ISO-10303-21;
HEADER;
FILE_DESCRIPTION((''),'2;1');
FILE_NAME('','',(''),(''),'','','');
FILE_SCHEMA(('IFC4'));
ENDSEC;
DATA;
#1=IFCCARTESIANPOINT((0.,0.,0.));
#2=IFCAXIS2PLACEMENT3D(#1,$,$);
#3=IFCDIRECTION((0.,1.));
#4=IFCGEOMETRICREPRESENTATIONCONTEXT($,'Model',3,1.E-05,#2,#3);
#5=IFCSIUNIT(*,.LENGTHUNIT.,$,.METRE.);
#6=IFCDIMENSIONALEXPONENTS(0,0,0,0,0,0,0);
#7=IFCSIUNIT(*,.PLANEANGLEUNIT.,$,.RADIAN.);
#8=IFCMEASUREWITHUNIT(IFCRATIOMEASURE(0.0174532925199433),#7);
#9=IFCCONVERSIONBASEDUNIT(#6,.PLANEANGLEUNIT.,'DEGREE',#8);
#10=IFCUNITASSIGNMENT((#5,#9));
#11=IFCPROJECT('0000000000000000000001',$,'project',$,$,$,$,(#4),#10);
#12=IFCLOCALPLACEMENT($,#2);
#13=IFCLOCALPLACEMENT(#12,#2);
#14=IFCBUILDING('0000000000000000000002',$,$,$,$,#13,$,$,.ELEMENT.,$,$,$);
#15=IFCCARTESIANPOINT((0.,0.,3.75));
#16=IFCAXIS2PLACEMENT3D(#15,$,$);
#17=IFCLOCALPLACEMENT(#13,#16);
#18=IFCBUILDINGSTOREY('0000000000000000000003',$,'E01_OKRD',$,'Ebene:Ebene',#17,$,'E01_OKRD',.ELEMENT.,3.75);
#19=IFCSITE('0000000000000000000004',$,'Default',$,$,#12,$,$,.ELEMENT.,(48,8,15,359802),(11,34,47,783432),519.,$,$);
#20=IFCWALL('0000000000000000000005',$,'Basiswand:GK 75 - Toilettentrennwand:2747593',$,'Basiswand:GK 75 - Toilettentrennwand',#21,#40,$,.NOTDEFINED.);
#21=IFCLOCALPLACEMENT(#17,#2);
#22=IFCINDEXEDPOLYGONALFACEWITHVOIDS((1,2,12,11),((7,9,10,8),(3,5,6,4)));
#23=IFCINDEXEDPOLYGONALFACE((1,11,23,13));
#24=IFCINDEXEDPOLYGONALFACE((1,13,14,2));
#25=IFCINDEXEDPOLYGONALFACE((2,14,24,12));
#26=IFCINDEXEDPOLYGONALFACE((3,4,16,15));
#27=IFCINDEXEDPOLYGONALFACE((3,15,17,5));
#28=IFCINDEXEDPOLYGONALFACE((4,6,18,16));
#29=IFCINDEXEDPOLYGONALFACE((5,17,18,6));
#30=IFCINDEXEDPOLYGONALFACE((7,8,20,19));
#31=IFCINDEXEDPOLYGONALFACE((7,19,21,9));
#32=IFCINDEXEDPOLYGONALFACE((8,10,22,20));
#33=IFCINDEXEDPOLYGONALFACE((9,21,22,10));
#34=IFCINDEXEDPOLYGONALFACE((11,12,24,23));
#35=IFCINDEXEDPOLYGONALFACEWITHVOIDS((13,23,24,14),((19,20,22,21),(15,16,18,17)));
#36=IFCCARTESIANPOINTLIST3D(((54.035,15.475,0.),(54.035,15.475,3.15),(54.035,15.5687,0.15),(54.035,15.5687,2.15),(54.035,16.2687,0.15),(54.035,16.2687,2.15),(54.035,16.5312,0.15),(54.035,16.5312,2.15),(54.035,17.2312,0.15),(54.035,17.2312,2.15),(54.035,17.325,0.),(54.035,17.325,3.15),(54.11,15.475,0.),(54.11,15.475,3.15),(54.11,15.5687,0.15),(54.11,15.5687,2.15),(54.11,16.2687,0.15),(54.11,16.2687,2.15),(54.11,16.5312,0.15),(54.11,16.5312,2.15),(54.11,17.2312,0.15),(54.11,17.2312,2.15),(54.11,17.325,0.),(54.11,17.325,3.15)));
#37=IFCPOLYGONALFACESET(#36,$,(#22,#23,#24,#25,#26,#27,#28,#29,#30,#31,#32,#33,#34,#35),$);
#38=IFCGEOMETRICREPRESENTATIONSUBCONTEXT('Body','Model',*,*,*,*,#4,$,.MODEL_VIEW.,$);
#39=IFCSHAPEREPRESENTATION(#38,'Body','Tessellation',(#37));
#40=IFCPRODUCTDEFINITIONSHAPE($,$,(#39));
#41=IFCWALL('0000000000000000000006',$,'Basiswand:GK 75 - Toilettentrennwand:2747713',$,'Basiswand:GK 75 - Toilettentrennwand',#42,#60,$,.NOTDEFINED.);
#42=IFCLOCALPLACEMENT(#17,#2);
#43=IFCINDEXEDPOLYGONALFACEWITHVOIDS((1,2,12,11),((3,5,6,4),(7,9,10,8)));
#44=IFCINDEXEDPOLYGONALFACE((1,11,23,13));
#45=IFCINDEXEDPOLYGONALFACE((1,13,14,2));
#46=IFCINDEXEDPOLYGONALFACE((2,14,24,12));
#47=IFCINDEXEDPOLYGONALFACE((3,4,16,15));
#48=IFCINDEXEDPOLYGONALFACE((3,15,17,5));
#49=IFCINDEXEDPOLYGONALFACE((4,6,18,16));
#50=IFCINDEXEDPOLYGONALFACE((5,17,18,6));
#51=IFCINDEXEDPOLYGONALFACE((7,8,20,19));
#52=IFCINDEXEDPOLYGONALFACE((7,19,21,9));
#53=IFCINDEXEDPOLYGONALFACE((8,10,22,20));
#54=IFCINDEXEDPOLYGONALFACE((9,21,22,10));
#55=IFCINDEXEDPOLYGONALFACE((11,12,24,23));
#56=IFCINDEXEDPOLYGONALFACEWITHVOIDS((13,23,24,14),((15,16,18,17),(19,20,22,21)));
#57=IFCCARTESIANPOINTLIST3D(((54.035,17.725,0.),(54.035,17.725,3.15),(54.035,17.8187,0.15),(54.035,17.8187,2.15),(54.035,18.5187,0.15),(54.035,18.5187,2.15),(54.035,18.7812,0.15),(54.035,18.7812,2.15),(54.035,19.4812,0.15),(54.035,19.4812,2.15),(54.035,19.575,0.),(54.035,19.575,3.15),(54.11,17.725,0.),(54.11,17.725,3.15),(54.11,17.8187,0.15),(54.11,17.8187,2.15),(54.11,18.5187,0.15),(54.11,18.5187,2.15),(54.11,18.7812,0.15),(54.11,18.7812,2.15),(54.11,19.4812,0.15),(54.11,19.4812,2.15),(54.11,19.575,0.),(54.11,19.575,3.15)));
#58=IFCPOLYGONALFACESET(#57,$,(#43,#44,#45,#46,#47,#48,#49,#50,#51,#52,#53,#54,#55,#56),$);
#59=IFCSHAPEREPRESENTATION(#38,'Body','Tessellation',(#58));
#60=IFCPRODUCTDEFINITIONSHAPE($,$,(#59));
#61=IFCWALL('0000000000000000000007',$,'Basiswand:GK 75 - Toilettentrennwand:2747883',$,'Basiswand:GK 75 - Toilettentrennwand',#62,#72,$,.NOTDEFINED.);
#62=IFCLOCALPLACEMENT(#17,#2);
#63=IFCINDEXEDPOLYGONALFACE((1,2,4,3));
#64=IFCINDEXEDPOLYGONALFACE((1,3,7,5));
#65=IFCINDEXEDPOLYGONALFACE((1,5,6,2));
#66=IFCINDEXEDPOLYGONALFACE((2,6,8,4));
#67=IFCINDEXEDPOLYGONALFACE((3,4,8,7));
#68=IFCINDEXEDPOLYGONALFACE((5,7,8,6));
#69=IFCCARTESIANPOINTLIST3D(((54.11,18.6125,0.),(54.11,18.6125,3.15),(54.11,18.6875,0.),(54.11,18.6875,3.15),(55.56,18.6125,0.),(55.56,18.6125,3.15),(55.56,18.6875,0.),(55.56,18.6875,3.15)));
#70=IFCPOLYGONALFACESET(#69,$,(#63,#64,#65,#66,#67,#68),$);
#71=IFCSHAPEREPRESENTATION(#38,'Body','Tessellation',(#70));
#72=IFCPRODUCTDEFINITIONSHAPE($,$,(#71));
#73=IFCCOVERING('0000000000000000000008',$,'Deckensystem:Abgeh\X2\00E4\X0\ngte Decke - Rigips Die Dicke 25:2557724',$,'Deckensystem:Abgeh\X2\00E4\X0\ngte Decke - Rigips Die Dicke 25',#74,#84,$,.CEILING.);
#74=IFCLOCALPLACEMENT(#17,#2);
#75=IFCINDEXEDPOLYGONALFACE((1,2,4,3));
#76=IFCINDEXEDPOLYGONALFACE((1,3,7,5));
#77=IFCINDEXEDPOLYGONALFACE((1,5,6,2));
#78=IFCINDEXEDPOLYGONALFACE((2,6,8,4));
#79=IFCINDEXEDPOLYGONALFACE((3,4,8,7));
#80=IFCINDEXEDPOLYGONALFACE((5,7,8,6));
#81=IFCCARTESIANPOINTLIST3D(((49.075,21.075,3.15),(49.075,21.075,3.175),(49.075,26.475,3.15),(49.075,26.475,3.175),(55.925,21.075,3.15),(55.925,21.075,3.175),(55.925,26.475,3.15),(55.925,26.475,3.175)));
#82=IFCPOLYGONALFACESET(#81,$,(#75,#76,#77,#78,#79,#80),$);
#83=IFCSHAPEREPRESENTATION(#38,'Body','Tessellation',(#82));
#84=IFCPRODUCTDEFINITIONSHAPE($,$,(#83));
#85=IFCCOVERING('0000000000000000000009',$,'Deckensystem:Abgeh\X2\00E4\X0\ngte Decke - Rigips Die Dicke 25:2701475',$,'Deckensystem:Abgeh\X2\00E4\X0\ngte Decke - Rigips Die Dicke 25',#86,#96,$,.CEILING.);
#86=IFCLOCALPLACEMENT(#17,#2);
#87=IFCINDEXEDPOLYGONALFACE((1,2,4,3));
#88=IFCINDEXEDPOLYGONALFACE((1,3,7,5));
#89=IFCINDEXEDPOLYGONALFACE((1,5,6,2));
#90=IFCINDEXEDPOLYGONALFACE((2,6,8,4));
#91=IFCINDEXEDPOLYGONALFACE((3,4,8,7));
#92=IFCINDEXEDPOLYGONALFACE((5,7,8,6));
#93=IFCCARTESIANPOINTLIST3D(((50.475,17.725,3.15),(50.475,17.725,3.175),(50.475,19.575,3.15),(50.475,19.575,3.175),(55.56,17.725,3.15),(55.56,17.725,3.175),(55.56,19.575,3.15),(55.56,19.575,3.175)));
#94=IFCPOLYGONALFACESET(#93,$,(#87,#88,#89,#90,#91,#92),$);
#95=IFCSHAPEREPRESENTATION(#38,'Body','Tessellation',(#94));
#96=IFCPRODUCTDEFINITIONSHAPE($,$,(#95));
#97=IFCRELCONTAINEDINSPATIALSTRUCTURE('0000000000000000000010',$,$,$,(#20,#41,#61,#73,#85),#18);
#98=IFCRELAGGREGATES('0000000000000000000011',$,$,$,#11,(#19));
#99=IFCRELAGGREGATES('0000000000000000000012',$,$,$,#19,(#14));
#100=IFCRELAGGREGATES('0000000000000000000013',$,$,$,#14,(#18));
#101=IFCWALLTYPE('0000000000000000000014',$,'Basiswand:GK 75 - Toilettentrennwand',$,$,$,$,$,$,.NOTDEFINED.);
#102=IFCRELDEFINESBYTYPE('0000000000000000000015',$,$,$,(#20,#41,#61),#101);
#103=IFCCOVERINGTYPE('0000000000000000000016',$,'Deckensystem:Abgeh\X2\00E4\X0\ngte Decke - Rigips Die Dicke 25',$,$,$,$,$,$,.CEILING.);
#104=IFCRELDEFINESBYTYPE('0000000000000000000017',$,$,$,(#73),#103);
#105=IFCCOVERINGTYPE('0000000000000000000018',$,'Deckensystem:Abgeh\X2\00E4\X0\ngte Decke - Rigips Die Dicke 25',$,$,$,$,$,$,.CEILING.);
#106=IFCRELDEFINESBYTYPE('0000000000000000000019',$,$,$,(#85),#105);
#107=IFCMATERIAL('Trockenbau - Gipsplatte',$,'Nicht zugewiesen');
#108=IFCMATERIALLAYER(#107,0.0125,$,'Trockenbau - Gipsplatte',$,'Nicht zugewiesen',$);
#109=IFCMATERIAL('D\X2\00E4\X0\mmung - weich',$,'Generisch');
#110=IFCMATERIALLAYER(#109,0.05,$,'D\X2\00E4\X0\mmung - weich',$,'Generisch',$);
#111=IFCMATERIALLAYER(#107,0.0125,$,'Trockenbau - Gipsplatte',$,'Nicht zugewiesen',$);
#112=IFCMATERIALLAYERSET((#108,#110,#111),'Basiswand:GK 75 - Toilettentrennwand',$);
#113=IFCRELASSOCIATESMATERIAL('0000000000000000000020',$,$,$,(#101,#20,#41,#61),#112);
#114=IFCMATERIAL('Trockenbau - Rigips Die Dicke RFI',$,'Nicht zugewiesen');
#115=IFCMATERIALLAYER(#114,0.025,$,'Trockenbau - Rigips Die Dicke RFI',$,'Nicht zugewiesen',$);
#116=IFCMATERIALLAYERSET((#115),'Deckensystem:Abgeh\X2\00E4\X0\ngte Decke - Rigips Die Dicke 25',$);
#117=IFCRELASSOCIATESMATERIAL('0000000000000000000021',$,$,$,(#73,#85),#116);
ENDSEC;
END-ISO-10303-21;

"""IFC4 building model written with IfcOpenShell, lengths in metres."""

from ifc_helpers import new_model, entity, si_unit, converted_unit, direction, frame, frame_2d, origin, origin_2d_with_axis, place, context, subcontext, project, spatial, rectangle, extrude, material, layer, layer_set, layer_usage, type_object, element, save


model = new_model("IFC4")

# Units and contexts
model_context = context("Model", 3, precision=1e-05, world=origin(), true_north=direction((0.0, 1.0)))
body_context = subcontext(model_context, "Body", "Model", "MODEL_VIEW")
ifc_project = project(units=[si_unit("LENGTHUNIT", "METRE"), converted_unit("PLANEANGLEUNIT", "DEGREE", entity("IfcRatioMeasure", 0.0174532925199433), si_unit("PLANEANGLEUNIT", "RADIAN"), dimensions=[0, 0, 0, 0, 0, 0, 0])], contexts=[model_context])

# Site, building, storey
site_placement = place(None, frame((0.0, 0.0, 0.0)))
site = spatial("IfcSite", under=ifc_project, at=site_placement, Name="Default", CompositionType="ELEMENT", RefLatitude=(48, 8, 15, 359802), RefLongitude=(11, 34, 47, 783432), RefElevation=519.0)
building_placement = place(site_placement, origin())
building = spatial("IfcBuilding", under=site, at=building_placement, CompositionType="ELEMENT")
storey_placement = place(building_placement, frame((0.0, 0.0, 3.75)))
storey = spatial("IfcBuildingStorey", under=building, at=storey_placement, Name="E01_OKRD", ObjectType="Ebene:Ebene", LongName="E01_OKRD", CompositionType="ELEMENT", Elevation=3.75)

# Shared definitions
ifc_material_1 = material(Name="Trockenbau - Gipsplatte", Category="Nicht zugewiesen")
ifc_material_2 = material(Name="Dämmung - weich", Category="Generisch")

# Walls, openings
ifc_layer_1 = layer(ifc_material_1, 0.0125, Name="Trockenbau - Gipsplatte", Category="Nicht zugewiesen")
ifc_layer_2 = layer(ifc_material_2, 0.05, Name="Dämmung - weich", Category="Generisch")
ifc_layer_3 = layer(ifc_material_1, 0.0125, Name="Trockenbau - Gipsplatte", Category="Nicht zugewiesen")
ifc_layer_set_1 = layer_set([ifc_layer_1, ifc_layer_2, ifc_layer_3], Name="Basiswand:GK 75 - Toilettentrennwand")
ifc_layer_usage_1 = layer_usage(ifc_layer_set_1, "AXIS2", "NEGATIVE", 0.0375)
wall_type_1 = type_object("IfcWallType", Name="Basiswand:GK 75 - Toilettentrennwand", PredefinedType="NOTDEFINED", material=ifc_layer_set_1)
wall_1_placement = place(storey_placement, frame((54.0725, 17.325, 0.0), z_axis=(0.0, 0.0, 1.0), x_axis=(0.0, -1.0, 0.0)))
wall_1 = element("IfcWall", 1, at=wall_1_placement, inside=storey, type_object=wall_type_1, material=ifc_layer_usage_1, Name="Basiswand:GK 75 - Toilettentrennwand:2747593", ObjectType="Basiswand:GK 75 - Toilettentrennwand", PredefinedType="NOTDEFINED", context=body_context, shape_type="SweptSolid", body=[
    extrude(rectangle(XDim=1.85, YDim=0.075, at=frame_2d((0.925, 0.0), x_axis=(-1.0, 0.0))), origin(), (0.0, 0.0, 1.0), 3.15),
])
opening_1_placement = place(wall_1_placement, frame((0.7937, -0.0375, 0.15)))
element("IfcOpeningElement", 2, at=opening_1_placement, cuts=wall_1, ObjectType="Opening", PredefinedType="OPENING", context=body_context, shape_type="SweptSolid", body=[
    extrude(rectangle(XDim=2.0, YDim=0.7, at=frame_2d((0.0, 0.0), x_axis=(1.0, 0.0))), frame((-0.35, 0.0, 1.0), z_axis=(0.0, 1.0, 0.0), x_axis=(0.0, 0.0, -1.0)), (0.0, 0.0, 1.0), 0.075),
])
opening_2_placement = place(wall_1_placement, frame((1.7563, -0.0375, 0.15)))
element("IfcOpeningElement", 3, at=opening_2_placement, cuts=wall_1, ObjectType="Opening", PredefinedType="OPENING", context=body_context, shape_type="SweptSolid", body=[
    extrude(rectangle(XDim=2.0, YDim=0.7, at=frame_2d((0.0, 0.0), x_axis=(1.0, 0.0))), frame((-0.35, 0.0, 1.0), z_axis=(0.0, 1.0, 0.0), x_axis=(0.0, 0.0, -1.0)), (0.0, 0.0, 1.0), 0.075),
])
ifc_layer_usage_2 = layer_usage(ifc_layer_set_1, "AXIS2", "NEGATIVE", 0.0375)
wall_2_placement = place(storey_placement, frame((54.0725, 17.725, 0.0), z_axis=(0.0, 0.0, 1.0), x_axis=(0.0, 1.0, 0.0)))
wall_2 = element("IfcWall", 4, at=wall_2_placement, inside=storey, type_object=wall_type_1, material=ifc_layer_usage_2, Name="Basiswand:GK 75 - Toilettentrennwand:2747713", ObjectType="Basiswand:GK 75 - Toilettentrennwand", PredefinedType="NOTDEFINED", context=body_context, shape_type="SweptSolid", body=[
    extrude(rectangle(XDim=1.85, YDim=0.075, at=frame_2d((0.925, 0.0), x_axis=(-1.0, 0.0))), origin(), (0.0, 0.0, 1.0), 3.15),
])
opening_3_placement = place(wall_2_placement, frame((1.0563, 0.0375, 0.15)))
element("IfcOpeningElement", 5, at=opening_3_placement, cuts=wall_2, ObjectType="Opening", PredefinedType="OPENING", context=body_context, shape_type="SweptSolid", body=[
    extrude(rectangle(XDim=2.0, YDim=0.7, at=frame_2d((0.0, 0.0), x_axis=(1.0, 0.0))), frame((0.35, -0.075, 1.0), z_axis=(0.0, 1.0, 0.0), x_axis=(0.0, 0.0, -1.0)), (0.0, 0.0, 1.0), 0.075),
])
opening_4_placement = place(wall_2_placement, frame((0.0938, 0.0375, 0.15)))
element("IfcOpeningElement", 6, at=opening_4_placement, cuts=wall_2, ObjectType="Opening", PredefinedType="OPENING", context=body_context, shape_type="SweptSolid", body=[
    extrude(rectangle(XDim=2.0, YDim=0.7, at=frame_2d((0.0, 0.0), x_axis=(1.0, 0.0))), frame((0.35, -0.075, 1.0), z_axis=(0.0, 1.0, 0.0), x_axis=(0.0, 0.0, -1.0)), (0.0, 0.0, 1.0), 0.075),
])

# Wall
ifc_layer_usage_3 = layer_usage(ifc_layer_set_1, "AXIS2", "NEGATIVE", 0.0375)
wall_3_placement = place(storey_placement, frame((54.11, 18.65, 0.0)))
element("IfcWall", 7, at=wall_3_placement, inside=storey, type_object=wall_type_1, material=ifc_layer_usage_3, Name="Basiswand:GK 75 - Toilettentrennwand:2747883", ObjectType="Basiswand:GK 75 - Toilettentrennwand", PredefinedType="NOTDEFINED", context=body_context, shape_type="SweptSolid", body=[
    extrude(rectangle(XDim=1.45, YDim=0.075, at=frame_2d((0.725, 0.0), x_axis=(-1.0, 0.0))), origin(), (0.0, 0.0, 1.0), 3.15),
])

# Coverings
ifc_material_3 = material(Name="Trockenbau - Rigips Die Dicke RFI", Category="Nicht zugewiesen")
ifc_layer_4 = layer(ifc_material_3, 0.025, Name="Trockenbau - Rigips Die Dicke RFI", Category="Nicht zugewiesen")
ifc_layer_set_2 = layer_set([ifc_layer_4], Name="Deckensystem:Abgehängte Decke - Rigips Die Dicke 25")
ifc_layer_usage_4 = layer_usage(ifc_layer_set_2, "AXIS3", "POSITIVE", 0.0)
covering_type_1 = type_object("IfcCoveringType", Name="Deckensystem:Abgehängte Decke - Rigips Die Dicke 25", PredefinedType="CEILING")
covering_1_placement = place(storey_placement, frame((49.075, 21.075, 3.15)))
element("IfcCovering", 8, at=covering_1_placement, inside=storey, type_object=covering_type_1, material=ifc_layer_usage_4, Name="Deckensystem:Abgehängte Decke - Rigips Die Dicke 25:2557724", ObjectType="Deckensystem:Abgehängte Decke - Rigips Die Dicke 25", PredefinedType="CEILING", context=body_context, shape_type="SweptSolid", body=[
    extrude(rectangle(XDim=6.85, YDim=5.4, at=origin_2d_with_axis()), frame((3.425, 2.7, 0.0), z_axis=(0.0, 0.0, 1.0), x_axis=(-1.0, 0.0, 0.0)), (0.0, 0.0, 1.0), 0.025),
])
ifc_layer_usage_5 = layer_usage(ifc_layer_set_2, "AXIS3", "POSITIVE", 0.0)
covering_type_2 = type_object("IfcCoveringType", Name="Deckensystem:Abgehängte Decke - Rigips Die Dicke 25", PredefinedType="CEILING")
covering_2_placement = place(storey_placement, frame((50.475, 17.725, 3.15)))
element("IfcCovering", 9, at=covering_2_placement, inside=storey, type_object=covering_type_2, material=ifc_layer_usage_5, Name="Deckensystem:Abgehängte Decke - Rigips Die Dicke 25:2701475", ObjectType="Deckensystem:Abgehängte Decke - Rigips Die Dicke 25", PredefinedType="CEILING", context=body_context, shape_type="SweptSolid", body=[
    extrude(rectangle(XDim=5.085, YDim=1.85, at=frame_2d((0.0, 0.0), x_axis=(1.0, 0.0))), frame((2.5425, 0.925, 0.0), z_axis=(0.0, 0.0, 1.0), x_axis=(-1.0, 0.0, 0.0)), (0.0, 0.0, 1.0), 0.025),
])

save(model, "model.ifc")
